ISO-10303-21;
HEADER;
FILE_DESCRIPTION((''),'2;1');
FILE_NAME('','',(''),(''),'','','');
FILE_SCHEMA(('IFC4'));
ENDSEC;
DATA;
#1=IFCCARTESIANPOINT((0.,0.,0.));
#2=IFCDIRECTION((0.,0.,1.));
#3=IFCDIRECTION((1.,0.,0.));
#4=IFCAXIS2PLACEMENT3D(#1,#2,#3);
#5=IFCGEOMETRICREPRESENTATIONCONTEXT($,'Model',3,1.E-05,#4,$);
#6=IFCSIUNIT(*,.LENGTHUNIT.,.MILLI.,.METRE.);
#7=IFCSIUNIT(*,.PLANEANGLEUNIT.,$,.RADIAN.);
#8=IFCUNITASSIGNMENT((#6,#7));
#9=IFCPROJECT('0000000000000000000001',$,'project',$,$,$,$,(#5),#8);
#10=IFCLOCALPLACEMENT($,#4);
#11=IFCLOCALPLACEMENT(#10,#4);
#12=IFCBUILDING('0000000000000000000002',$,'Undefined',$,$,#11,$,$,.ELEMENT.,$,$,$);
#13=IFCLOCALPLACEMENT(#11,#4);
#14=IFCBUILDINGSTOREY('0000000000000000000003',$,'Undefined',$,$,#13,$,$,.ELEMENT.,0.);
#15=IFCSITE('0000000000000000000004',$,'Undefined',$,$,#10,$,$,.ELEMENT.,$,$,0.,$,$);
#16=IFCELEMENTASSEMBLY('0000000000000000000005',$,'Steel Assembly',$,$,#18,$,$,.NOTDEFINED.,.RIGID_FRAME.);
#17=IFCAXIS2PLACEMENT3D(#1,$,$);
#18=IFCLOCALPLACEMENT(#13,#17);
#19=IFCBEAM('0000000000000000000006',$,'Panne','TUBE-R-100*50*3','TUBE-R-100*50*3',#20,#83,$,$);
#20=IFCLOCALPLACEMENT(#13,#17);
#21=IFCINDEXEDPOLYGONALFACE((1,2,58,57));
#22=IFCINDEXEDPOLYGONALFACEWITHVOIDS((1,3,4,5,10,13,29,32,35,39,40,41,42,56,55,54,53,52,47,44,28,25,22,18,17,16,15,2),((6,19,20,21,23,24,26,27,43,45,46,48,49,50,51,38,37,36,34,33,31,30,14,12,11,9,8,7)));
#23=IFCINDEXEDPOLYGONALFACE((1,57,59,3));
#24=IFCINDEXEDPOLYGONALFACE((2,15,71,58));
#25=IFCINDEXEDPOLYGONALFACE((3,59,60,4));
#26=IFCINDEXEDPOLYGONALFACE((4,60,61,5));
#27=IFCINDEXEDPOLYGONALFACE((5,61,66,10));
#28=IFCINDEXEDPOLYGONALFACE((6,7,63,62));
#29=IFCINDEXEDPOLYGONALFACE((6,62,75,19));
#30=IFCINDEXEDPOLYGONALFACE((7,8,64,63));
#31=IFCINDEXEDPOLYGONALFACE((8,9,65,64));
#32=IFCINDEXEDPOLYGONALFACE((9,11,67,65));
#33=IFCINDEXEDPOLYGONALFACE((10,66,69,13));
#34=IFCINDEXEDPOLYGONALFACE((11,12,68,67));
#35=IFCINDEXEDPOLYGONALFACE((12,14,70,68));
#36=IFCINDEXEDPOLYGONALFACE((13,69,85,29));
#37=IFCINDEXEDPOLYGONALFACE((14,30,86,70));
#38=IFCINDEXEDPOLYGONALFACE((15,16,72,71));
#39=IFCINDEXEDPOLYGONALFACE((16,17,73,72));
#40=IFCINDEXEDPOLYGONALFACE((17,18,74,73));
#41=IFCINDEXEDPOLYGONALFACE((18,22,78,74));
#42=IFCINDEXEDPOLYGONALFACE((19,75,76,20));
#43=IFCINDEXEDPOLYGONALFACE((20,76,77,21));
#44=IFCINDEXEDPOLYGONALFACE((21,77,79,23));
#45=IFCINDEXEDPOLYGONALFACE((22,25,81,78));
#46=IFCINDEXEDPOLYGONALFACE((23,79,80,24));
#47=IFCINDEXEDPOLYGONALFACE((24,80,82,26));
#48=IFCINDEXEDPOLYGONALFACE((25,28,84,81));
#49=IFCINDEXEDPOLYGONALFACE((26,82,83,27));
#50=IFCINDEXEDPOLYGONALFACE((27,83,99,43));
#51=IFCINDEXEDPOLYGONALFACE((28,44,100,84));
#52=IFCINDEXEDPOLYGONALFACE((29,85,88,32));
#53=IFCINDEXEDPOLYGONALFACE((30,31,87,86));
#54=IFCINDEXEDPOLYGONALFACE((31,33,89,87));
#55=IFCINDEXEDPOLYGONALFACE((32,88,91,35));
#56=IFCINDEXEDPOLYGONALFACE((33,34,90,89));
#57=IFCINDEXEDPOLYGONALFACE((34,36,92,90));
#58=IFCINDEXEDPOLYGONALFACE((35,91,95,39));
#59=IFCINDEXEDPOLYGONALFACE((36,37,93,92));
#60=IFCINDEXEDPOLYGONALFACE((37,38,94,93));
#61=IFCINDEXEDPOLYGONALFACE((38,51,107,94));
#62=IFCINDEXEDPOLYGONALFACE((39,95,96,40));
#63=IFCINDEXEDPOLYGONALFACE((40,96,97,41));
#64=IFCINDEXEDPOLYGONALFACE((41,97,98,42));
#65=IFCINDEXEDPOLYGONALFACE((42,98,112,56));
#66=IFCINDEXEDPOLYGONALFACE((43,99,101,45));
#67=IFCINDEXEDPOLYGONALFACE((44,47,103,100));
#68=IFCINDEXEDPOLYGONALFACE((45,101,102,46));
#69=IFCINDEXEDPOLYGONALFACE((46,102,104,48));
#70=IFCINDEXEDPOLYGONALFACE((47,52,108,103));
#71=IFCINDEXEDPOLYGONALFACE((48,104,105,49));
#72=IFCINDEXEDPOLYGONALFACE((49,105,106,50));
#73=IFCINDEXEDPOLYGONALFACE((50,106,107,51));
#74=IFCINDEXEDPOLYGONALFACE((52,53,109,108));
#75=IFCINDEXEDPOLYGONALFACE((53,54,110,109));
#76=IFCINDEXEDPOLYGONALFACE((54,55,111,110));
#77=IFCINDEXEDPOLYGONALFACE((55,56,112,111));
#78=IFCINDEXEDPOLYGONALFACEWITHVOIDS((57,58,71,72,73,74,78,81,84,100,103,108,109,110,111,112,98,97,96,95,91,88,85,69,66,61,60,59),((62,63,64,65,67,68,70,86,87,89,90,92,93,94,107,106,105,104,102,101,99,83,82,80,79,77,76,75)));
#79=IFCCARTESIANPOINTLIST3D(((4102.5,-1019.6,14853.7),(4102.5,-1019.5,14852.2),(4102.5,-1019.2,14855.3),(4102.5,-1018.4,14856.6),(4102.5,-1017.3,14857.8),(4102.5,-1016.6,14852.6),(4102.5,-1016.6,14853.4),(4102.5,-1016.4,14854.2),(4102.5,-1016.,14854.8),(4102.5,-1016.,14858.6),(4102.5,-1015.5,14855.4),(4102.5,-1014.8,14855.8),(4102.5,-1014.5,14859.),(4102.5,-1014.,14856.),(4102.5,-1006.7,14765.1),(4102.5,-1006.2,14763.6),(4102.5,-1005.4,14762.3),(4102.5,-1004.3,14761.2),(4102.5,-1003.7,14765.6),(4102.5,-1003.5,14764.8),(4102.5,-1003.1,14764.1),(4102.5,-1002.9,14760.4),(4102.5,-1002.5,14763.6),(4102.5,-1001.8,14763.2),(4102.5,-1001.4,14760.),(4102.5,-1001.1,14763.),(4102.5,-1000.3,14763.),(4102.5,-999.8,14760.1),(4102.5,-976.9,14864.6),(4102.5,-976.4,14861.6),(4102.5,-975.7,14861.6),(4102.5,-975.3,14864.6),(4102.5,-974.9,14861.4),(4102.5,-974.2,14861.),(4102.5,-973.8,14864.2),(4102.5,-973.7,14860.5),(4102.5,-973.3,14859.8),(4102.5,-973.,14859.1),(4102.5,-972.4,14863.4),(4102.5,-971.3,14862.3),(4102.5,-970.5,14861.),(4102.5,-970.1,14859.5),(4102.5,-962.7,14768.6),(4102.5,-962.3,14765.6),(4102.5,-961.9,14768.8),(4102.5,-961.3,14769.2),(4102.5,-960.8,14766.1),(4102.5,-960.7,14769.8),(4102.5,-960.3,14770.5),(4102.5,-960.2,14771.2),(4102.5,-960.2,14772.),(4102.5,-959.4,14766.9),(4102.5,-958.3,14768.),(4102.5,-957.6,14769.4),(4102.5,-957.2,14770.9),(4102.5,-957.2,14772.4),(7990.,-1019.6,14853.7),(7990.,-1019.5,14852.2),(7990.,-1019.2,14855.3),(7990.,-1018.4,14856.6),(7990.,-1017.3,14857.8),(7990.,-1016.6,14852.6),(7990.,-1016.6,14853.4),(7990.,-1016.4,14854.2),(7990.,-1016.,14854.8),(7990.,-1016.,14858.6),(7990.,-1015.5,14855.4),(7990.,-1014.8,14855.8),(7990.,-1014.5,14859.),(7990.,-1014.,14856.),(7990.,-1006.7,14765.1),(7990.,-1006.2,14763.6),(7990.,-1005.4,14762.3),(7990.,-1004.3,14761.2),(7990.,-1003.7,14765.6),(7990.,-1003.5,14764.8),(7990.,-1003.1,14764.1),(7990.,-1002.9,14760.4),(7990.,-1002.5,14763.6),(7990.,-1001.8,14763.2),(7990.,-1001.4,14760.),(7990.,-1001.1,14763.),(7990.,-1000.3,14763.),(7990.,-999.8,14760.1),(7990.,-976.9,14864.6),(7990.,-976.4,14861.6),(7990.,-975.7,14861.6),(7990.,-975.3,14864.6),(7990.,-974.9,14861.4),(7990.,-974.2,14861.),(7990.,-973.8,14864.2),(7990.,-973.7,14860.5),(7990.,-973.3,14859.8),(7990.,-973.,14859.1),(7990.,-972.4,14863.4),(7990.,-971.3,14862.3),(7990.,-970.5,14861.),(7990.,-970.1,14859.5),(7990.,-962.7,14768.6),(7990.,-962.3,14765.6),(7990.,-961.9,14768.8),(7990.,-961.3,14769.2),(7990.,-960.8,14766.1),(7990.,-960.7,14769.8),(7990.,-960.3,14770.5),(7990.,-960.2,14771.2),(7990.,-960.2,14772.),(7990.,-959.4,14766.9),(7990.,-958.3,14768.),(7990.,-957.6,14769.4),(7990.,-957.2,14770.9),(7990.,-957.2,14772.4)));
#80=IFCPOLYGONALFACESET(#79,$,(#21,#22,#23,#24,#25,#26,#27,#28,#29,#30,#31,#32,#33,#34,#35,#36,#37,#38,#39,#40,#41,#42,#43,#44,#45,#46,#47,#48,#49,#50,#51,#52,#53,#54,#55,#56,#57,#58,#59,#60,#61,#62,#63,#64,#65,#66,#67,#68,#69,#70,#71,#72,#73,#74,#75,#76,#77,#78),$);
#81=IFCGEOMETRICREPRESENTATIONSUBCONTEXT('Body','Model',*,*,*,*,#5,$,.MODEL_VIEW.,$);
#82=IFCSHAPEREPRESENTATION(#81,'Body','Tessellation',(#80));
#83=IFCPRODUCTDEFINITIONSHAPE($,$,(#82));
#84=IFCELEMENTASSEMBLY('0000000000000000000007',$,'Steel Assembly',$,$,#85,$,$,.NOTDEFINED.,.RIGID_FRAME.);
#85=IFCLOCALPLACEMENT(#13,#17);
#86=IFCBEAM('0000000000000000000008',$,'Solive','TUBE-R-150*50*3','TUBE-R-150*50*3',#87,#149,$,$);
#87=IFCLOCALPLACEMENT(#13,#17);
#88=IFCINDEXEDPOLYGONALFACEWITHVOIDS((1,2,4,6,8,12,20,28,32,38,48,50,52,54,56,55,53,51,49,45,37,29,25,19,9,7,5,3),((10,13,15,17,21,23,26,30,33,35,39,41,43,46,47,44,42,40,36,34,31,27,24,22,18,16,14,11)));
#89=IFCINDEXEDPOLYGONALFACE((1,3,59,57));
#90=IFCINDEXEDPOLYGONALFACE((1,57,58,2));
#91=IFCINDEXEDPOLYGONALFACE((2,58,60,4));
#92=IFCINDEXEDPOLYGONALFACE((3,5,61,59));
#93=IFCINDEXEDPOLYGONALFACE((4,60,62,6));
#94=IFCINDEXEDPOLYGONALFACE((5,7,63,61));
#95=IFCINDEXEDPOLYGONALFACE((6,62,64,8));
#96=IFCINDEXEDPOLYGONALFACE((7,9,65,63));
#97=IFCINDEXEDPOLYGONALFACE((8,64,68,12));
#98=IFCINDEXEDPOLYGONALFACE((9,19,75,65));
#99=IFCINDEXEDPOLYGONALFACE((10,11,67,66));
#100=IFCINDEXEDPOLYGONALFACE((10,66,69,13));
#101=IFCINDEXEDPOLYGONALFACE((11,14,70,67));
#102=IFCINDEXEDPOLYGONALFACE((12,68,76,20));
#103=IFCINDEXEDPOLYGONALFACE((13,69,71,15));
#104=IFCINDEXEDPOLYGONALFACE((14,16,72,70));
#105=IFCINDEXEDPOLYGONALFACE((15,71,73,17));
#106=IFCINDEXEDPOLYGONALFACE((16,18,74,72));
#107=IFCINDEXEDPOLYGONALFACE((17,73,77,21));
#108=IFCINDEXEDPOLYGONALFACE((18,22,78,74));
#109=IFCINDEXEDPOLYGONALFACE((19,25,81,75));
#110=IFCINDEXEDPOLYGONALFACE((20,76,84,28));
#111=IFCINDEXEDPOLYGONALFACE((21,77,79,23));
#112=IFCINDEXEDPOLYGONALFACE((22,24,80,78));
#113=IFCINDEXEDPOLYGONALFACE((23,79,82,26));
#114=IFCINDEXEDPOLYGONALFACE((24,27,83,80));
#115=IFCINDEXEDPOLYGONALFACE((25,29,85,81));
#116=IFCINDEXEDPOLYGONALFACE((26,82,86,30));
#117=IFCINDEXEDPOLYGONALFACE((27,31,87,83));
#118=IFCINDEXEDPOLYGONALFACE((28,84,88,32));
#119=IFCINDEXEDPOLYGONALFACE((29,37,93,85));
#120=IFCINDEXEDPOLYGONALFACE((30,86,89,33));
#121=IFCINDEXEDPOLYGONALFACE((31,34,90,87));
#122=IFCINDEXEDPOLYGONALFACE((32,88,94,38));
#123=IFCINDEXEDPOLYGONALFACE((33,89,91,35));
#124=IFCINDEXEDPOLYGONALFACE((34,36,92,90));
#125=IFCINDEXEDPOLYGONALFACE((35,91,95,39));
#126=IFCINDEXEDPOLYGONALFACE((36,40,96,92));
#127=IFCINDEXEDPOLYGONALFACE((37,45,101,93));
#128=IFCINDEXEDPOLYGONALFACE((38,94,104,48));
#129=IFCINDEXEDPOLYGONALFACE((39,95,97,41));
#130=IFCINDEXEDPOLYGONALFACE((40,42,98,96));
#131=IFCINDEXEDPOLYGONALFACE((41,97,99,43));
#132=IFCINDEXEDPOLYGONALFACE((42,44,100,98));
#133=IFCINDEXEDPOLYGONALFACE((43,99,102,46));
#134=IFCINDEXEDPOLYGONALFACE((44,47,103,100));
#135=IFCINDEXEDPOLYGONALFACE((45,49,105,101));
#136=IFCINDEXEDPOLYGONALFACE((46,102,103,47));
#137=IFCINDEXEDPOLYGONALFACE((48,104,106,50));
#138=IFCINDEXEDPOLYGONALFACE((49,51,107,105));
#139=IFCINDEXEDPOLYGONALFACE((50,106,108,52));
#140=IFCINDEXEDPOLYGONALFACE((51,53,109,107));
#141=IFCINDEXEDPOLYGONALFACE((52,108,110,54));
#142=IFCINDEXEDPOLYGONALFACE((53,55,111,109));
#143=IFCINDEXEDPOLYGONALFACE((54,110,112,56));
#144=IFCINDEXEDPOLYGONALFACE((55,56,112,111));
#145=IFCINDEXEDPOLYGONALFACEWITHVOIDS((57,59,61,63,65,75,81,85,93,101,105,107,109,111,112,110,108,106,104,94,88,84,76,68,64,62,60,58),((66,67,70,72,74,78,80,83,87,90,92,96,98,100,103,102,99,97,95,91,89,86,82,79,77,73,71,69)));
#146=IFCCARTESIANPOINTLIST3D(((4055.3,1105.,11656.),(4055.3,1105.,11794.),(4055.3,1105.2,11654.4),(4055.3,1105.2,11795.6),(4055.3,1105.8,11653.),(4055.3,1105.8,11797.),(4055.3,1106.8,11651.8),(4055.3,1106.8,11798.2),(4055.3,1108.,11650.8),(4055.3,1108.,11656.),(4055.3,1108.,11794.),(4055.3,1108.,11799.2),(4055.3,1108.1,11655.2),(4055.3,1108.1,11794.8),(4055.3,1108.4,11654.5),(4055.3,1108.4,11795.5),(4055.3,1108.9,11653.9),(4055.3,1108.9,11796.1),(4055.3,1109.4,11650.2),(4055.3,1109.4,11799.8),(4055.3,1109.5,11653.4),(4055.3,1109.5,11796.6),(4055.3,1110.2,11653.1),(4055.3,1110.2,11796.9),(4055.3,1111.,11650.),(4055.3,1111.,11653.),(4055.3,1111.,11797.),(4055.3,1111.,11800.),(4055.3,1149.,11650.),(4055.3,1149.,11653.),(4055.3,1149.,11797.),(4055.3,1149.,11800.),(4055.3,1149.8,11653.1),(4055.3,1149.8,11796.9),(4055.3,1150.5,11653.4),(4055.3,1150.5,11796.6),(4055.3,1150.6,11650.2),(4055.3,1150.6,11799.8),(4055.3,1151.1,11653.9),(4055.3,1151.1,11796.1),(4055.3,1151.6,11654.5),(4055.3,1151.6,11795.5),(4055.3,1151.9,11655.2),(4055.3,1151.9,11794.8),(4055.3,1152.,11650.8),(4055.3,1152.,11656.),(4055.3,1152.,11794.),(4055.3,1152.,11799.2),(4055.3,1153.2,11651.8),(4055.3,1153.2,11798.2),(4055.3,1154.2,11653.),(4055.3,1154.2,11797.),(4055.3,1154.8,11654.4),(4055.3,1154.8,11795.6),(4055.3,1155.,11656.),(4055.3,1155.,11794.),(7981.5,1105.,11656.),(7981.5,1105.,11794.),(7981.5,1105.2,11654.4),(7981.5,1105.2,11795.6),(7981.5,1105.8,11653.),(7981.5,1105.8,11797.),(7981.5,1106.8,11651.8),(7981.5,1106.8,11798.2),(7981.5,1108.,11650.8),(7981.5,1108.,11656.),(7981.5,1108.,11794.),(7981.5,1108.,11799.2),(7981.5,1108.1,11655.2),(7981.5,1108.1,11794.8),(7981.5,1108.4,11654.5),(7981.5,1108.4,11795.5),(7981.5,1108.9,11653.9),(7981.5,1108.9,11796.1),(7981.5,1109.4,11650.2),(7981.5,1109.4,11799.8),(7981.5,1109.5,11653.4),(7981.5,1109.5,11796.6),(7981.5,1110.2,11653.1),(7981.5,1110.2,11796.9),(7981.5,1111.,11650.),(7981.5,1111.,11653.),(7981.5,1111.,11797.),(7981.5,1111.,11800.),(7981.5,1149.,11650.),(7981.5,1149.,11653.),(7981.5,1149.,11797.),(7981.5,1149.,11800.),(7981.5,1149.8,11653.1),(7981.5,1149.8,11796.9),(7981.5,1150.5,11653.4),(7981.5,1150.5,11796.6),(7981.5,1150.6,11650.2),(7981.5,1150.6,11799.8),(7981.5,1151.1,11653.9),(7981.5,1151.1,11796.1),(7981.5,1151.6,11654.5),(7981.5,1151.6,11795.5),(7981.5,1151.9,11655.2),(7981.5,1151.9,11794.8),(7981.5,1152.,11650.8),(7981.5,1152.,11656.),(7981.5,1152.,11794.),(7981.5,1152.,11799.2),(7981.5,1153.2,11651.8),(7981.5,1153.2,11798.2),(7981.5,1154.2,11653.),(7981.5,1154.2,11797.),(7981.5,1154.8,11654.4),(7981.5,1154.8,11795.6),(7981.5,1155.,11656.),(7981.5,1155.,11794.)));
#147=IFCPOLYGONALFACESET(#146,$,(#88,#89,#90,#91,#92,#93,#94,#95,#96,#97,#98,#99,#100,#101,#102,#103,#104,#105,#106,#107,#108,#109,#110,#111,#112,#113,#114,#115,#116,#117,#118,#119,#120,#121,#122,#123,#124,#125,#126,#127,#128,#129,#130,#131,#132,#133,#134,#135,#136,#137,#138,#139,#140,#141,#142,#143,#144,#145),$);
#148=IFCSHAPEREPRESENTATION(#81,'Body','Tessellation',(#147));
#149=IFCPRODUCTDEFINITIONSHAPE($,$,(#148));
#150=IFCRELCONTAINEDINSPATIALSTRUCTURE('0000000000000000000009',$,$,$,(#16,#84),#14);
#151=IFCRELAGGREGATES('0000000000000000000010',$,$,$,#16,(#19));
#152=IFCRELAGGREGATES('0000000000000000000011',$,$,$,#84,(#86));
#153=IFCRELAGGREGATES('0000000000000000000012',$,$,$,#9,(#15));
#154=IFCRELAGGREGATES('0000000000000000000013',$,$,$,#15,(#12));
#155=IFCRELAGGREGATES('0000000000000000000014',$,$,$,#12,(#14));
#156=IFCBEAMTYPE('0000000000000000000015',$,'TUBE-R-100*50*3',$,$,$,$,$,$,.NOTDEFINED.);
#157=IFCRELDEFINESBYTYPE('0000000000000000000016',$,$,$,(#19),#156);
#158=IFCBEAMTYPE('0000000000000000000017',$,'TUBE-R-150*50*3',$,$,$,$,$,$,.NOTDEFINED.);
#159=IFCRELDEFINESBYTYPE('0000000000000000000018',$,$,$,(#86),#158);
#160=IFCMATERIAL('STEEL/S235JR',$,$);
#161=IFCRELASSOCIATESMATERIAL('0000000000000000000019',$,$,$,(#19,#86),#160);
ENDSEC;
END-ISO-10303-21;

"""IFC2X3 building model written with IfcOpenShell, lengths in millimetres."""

from ifc_helpers import new_model, si_unit, frame, origin_with_axes, origin_2d_with_axis, place, context, subcontext, project, spatial, hollow_rectangle, extrude, material, type_object, element, aggregate, save


model = new_model("IFC2X3")

# Units and contexts
model_context = context("Model", 3, precision=1e-05, world=origin_with_axes())
body_context = subcontext(model_context, "Body", "Model", "MODEL_VIEW")
ifc_project = project(units=[si_unit("LENGTHUNIT", "METRE", prefix="MILLI"), si_unit("PLANEANGLEUNIT", "RADIAN")], contexts=[model_context])

# Site, building, storey
site_placement = place(None, origin_with_axes())
site = spatial("IfcSite", under=ifc_project, at=site_placement, Name="Undefined", CompositionType="ELEMENT", RefElevation=0.0)
building_placement = place(site_placement, origin_with_axes())
building = spatial("IfcBuilding", under=site, at=building_placement, Name="Undefined", CompositionType="ELEMENT")
storey_placement = place(building_placement, origin_with_axes())
storey = spatial("IfcBuildingStorey", under=building, at=storey_placement, Name="Undefined", CompositionType="ELEMENT", Elevation=0.0)

# Element assemblies, beams
ifc_material_1 = material(Name="STEEL/S235JR")
beam_type_1 = type_object("IfcBeamType", Name="TUBE-R-100*50*3", PredefinedType="NOTDEFINED")
assembly_1_placement = place(storey_placement, origin_with_axes())
assembly_1 = element("IfcElementAssembly", 1, at=assembly_1_placement, inside=storey, Name="Steel Assembly", AssemblyPlace="NOTDEFINED", PredefinedType="RIGID_FRAME")
beam_1_placement = place(assembly_1_placement, frame((4102.5, -988.4, 14812.3), z_axis=(0.0, 0.146286, -0.989242), x_axis=(1.0, 0.0, 0.0)))
beam_1 = element("IfcBeam", 2, at=beam_1_placement, type_object=beam_type_1, material=ifc_material_1, Name="Panne", Description="TUBE-R-100*50*3", ObjectType="TUBE-R-100*50*3", context=body_context, shape_type="SweptSolid", body=[
    extrude(hollow_rectangle(XDim=50.0, YDim=100.0, WallThickness=3.0, InnerFilletRadius=3.0, OuterFilletRadius=6.0, at=origin_2d_with_axis()), frame((3887.5, 0.0, 0.0), z_axis=(-1.0, 0.0, 0.0), x_axis=(0.0, -1.0, 0.0)), (0.0, 0.0, 1.0), 3887.5),
])
aggregate(assembly_1, [beam_1])
assembly_2_placement = place(storey_placement, origin_with_axes())
assembly_2 = element("IfcElementAssembly", 3, at=assembly_2_placement, inside=storey, Name="Steel Assembly", AssemblyPlace="NOTDEFINED", PredefinedType="RIGID_FRAME")
beam_type_2 = type_object("IfcBeamType", Name="TUBE-R-150*50*3", PredefinedType="NOTDEFINED")
beam_2_placement = place(assembly_2_placement, frame((4055.3, 1130.0, 11725.0), z_axis=(0.0, 0.0, 1.0), x_axis=(1.0, 0.0, 0.0)))
beam_2 = element("IfcBeam", 4, at=beam_2_placement, type_object=beam_type_2, material=ifc_material_1, Name="Solive", Description="TUBE-R-150*50*3", ObjectType="TUBE-R-150*50*3", context=body_context, shape_type="SweptSolid", body=[
    extrude(hollow_rectangle(XDim=50.0, YDim=150.0, WallThickness=3.0, InnerFilletRadius=3.0, OuterFilletRadius=6.0, at=origin_2d_with_axis()), frame((3926.2, 0.0, 0.0), z_axis=(-1.0, 0.0, 0.0), x_axis=(0.0, -1.0, 0.0)), (0.0, 0.0, 1.0), 3926.2),
])
aggregate(assembly_2, [beam_2])

save(model, "model.ifc")
